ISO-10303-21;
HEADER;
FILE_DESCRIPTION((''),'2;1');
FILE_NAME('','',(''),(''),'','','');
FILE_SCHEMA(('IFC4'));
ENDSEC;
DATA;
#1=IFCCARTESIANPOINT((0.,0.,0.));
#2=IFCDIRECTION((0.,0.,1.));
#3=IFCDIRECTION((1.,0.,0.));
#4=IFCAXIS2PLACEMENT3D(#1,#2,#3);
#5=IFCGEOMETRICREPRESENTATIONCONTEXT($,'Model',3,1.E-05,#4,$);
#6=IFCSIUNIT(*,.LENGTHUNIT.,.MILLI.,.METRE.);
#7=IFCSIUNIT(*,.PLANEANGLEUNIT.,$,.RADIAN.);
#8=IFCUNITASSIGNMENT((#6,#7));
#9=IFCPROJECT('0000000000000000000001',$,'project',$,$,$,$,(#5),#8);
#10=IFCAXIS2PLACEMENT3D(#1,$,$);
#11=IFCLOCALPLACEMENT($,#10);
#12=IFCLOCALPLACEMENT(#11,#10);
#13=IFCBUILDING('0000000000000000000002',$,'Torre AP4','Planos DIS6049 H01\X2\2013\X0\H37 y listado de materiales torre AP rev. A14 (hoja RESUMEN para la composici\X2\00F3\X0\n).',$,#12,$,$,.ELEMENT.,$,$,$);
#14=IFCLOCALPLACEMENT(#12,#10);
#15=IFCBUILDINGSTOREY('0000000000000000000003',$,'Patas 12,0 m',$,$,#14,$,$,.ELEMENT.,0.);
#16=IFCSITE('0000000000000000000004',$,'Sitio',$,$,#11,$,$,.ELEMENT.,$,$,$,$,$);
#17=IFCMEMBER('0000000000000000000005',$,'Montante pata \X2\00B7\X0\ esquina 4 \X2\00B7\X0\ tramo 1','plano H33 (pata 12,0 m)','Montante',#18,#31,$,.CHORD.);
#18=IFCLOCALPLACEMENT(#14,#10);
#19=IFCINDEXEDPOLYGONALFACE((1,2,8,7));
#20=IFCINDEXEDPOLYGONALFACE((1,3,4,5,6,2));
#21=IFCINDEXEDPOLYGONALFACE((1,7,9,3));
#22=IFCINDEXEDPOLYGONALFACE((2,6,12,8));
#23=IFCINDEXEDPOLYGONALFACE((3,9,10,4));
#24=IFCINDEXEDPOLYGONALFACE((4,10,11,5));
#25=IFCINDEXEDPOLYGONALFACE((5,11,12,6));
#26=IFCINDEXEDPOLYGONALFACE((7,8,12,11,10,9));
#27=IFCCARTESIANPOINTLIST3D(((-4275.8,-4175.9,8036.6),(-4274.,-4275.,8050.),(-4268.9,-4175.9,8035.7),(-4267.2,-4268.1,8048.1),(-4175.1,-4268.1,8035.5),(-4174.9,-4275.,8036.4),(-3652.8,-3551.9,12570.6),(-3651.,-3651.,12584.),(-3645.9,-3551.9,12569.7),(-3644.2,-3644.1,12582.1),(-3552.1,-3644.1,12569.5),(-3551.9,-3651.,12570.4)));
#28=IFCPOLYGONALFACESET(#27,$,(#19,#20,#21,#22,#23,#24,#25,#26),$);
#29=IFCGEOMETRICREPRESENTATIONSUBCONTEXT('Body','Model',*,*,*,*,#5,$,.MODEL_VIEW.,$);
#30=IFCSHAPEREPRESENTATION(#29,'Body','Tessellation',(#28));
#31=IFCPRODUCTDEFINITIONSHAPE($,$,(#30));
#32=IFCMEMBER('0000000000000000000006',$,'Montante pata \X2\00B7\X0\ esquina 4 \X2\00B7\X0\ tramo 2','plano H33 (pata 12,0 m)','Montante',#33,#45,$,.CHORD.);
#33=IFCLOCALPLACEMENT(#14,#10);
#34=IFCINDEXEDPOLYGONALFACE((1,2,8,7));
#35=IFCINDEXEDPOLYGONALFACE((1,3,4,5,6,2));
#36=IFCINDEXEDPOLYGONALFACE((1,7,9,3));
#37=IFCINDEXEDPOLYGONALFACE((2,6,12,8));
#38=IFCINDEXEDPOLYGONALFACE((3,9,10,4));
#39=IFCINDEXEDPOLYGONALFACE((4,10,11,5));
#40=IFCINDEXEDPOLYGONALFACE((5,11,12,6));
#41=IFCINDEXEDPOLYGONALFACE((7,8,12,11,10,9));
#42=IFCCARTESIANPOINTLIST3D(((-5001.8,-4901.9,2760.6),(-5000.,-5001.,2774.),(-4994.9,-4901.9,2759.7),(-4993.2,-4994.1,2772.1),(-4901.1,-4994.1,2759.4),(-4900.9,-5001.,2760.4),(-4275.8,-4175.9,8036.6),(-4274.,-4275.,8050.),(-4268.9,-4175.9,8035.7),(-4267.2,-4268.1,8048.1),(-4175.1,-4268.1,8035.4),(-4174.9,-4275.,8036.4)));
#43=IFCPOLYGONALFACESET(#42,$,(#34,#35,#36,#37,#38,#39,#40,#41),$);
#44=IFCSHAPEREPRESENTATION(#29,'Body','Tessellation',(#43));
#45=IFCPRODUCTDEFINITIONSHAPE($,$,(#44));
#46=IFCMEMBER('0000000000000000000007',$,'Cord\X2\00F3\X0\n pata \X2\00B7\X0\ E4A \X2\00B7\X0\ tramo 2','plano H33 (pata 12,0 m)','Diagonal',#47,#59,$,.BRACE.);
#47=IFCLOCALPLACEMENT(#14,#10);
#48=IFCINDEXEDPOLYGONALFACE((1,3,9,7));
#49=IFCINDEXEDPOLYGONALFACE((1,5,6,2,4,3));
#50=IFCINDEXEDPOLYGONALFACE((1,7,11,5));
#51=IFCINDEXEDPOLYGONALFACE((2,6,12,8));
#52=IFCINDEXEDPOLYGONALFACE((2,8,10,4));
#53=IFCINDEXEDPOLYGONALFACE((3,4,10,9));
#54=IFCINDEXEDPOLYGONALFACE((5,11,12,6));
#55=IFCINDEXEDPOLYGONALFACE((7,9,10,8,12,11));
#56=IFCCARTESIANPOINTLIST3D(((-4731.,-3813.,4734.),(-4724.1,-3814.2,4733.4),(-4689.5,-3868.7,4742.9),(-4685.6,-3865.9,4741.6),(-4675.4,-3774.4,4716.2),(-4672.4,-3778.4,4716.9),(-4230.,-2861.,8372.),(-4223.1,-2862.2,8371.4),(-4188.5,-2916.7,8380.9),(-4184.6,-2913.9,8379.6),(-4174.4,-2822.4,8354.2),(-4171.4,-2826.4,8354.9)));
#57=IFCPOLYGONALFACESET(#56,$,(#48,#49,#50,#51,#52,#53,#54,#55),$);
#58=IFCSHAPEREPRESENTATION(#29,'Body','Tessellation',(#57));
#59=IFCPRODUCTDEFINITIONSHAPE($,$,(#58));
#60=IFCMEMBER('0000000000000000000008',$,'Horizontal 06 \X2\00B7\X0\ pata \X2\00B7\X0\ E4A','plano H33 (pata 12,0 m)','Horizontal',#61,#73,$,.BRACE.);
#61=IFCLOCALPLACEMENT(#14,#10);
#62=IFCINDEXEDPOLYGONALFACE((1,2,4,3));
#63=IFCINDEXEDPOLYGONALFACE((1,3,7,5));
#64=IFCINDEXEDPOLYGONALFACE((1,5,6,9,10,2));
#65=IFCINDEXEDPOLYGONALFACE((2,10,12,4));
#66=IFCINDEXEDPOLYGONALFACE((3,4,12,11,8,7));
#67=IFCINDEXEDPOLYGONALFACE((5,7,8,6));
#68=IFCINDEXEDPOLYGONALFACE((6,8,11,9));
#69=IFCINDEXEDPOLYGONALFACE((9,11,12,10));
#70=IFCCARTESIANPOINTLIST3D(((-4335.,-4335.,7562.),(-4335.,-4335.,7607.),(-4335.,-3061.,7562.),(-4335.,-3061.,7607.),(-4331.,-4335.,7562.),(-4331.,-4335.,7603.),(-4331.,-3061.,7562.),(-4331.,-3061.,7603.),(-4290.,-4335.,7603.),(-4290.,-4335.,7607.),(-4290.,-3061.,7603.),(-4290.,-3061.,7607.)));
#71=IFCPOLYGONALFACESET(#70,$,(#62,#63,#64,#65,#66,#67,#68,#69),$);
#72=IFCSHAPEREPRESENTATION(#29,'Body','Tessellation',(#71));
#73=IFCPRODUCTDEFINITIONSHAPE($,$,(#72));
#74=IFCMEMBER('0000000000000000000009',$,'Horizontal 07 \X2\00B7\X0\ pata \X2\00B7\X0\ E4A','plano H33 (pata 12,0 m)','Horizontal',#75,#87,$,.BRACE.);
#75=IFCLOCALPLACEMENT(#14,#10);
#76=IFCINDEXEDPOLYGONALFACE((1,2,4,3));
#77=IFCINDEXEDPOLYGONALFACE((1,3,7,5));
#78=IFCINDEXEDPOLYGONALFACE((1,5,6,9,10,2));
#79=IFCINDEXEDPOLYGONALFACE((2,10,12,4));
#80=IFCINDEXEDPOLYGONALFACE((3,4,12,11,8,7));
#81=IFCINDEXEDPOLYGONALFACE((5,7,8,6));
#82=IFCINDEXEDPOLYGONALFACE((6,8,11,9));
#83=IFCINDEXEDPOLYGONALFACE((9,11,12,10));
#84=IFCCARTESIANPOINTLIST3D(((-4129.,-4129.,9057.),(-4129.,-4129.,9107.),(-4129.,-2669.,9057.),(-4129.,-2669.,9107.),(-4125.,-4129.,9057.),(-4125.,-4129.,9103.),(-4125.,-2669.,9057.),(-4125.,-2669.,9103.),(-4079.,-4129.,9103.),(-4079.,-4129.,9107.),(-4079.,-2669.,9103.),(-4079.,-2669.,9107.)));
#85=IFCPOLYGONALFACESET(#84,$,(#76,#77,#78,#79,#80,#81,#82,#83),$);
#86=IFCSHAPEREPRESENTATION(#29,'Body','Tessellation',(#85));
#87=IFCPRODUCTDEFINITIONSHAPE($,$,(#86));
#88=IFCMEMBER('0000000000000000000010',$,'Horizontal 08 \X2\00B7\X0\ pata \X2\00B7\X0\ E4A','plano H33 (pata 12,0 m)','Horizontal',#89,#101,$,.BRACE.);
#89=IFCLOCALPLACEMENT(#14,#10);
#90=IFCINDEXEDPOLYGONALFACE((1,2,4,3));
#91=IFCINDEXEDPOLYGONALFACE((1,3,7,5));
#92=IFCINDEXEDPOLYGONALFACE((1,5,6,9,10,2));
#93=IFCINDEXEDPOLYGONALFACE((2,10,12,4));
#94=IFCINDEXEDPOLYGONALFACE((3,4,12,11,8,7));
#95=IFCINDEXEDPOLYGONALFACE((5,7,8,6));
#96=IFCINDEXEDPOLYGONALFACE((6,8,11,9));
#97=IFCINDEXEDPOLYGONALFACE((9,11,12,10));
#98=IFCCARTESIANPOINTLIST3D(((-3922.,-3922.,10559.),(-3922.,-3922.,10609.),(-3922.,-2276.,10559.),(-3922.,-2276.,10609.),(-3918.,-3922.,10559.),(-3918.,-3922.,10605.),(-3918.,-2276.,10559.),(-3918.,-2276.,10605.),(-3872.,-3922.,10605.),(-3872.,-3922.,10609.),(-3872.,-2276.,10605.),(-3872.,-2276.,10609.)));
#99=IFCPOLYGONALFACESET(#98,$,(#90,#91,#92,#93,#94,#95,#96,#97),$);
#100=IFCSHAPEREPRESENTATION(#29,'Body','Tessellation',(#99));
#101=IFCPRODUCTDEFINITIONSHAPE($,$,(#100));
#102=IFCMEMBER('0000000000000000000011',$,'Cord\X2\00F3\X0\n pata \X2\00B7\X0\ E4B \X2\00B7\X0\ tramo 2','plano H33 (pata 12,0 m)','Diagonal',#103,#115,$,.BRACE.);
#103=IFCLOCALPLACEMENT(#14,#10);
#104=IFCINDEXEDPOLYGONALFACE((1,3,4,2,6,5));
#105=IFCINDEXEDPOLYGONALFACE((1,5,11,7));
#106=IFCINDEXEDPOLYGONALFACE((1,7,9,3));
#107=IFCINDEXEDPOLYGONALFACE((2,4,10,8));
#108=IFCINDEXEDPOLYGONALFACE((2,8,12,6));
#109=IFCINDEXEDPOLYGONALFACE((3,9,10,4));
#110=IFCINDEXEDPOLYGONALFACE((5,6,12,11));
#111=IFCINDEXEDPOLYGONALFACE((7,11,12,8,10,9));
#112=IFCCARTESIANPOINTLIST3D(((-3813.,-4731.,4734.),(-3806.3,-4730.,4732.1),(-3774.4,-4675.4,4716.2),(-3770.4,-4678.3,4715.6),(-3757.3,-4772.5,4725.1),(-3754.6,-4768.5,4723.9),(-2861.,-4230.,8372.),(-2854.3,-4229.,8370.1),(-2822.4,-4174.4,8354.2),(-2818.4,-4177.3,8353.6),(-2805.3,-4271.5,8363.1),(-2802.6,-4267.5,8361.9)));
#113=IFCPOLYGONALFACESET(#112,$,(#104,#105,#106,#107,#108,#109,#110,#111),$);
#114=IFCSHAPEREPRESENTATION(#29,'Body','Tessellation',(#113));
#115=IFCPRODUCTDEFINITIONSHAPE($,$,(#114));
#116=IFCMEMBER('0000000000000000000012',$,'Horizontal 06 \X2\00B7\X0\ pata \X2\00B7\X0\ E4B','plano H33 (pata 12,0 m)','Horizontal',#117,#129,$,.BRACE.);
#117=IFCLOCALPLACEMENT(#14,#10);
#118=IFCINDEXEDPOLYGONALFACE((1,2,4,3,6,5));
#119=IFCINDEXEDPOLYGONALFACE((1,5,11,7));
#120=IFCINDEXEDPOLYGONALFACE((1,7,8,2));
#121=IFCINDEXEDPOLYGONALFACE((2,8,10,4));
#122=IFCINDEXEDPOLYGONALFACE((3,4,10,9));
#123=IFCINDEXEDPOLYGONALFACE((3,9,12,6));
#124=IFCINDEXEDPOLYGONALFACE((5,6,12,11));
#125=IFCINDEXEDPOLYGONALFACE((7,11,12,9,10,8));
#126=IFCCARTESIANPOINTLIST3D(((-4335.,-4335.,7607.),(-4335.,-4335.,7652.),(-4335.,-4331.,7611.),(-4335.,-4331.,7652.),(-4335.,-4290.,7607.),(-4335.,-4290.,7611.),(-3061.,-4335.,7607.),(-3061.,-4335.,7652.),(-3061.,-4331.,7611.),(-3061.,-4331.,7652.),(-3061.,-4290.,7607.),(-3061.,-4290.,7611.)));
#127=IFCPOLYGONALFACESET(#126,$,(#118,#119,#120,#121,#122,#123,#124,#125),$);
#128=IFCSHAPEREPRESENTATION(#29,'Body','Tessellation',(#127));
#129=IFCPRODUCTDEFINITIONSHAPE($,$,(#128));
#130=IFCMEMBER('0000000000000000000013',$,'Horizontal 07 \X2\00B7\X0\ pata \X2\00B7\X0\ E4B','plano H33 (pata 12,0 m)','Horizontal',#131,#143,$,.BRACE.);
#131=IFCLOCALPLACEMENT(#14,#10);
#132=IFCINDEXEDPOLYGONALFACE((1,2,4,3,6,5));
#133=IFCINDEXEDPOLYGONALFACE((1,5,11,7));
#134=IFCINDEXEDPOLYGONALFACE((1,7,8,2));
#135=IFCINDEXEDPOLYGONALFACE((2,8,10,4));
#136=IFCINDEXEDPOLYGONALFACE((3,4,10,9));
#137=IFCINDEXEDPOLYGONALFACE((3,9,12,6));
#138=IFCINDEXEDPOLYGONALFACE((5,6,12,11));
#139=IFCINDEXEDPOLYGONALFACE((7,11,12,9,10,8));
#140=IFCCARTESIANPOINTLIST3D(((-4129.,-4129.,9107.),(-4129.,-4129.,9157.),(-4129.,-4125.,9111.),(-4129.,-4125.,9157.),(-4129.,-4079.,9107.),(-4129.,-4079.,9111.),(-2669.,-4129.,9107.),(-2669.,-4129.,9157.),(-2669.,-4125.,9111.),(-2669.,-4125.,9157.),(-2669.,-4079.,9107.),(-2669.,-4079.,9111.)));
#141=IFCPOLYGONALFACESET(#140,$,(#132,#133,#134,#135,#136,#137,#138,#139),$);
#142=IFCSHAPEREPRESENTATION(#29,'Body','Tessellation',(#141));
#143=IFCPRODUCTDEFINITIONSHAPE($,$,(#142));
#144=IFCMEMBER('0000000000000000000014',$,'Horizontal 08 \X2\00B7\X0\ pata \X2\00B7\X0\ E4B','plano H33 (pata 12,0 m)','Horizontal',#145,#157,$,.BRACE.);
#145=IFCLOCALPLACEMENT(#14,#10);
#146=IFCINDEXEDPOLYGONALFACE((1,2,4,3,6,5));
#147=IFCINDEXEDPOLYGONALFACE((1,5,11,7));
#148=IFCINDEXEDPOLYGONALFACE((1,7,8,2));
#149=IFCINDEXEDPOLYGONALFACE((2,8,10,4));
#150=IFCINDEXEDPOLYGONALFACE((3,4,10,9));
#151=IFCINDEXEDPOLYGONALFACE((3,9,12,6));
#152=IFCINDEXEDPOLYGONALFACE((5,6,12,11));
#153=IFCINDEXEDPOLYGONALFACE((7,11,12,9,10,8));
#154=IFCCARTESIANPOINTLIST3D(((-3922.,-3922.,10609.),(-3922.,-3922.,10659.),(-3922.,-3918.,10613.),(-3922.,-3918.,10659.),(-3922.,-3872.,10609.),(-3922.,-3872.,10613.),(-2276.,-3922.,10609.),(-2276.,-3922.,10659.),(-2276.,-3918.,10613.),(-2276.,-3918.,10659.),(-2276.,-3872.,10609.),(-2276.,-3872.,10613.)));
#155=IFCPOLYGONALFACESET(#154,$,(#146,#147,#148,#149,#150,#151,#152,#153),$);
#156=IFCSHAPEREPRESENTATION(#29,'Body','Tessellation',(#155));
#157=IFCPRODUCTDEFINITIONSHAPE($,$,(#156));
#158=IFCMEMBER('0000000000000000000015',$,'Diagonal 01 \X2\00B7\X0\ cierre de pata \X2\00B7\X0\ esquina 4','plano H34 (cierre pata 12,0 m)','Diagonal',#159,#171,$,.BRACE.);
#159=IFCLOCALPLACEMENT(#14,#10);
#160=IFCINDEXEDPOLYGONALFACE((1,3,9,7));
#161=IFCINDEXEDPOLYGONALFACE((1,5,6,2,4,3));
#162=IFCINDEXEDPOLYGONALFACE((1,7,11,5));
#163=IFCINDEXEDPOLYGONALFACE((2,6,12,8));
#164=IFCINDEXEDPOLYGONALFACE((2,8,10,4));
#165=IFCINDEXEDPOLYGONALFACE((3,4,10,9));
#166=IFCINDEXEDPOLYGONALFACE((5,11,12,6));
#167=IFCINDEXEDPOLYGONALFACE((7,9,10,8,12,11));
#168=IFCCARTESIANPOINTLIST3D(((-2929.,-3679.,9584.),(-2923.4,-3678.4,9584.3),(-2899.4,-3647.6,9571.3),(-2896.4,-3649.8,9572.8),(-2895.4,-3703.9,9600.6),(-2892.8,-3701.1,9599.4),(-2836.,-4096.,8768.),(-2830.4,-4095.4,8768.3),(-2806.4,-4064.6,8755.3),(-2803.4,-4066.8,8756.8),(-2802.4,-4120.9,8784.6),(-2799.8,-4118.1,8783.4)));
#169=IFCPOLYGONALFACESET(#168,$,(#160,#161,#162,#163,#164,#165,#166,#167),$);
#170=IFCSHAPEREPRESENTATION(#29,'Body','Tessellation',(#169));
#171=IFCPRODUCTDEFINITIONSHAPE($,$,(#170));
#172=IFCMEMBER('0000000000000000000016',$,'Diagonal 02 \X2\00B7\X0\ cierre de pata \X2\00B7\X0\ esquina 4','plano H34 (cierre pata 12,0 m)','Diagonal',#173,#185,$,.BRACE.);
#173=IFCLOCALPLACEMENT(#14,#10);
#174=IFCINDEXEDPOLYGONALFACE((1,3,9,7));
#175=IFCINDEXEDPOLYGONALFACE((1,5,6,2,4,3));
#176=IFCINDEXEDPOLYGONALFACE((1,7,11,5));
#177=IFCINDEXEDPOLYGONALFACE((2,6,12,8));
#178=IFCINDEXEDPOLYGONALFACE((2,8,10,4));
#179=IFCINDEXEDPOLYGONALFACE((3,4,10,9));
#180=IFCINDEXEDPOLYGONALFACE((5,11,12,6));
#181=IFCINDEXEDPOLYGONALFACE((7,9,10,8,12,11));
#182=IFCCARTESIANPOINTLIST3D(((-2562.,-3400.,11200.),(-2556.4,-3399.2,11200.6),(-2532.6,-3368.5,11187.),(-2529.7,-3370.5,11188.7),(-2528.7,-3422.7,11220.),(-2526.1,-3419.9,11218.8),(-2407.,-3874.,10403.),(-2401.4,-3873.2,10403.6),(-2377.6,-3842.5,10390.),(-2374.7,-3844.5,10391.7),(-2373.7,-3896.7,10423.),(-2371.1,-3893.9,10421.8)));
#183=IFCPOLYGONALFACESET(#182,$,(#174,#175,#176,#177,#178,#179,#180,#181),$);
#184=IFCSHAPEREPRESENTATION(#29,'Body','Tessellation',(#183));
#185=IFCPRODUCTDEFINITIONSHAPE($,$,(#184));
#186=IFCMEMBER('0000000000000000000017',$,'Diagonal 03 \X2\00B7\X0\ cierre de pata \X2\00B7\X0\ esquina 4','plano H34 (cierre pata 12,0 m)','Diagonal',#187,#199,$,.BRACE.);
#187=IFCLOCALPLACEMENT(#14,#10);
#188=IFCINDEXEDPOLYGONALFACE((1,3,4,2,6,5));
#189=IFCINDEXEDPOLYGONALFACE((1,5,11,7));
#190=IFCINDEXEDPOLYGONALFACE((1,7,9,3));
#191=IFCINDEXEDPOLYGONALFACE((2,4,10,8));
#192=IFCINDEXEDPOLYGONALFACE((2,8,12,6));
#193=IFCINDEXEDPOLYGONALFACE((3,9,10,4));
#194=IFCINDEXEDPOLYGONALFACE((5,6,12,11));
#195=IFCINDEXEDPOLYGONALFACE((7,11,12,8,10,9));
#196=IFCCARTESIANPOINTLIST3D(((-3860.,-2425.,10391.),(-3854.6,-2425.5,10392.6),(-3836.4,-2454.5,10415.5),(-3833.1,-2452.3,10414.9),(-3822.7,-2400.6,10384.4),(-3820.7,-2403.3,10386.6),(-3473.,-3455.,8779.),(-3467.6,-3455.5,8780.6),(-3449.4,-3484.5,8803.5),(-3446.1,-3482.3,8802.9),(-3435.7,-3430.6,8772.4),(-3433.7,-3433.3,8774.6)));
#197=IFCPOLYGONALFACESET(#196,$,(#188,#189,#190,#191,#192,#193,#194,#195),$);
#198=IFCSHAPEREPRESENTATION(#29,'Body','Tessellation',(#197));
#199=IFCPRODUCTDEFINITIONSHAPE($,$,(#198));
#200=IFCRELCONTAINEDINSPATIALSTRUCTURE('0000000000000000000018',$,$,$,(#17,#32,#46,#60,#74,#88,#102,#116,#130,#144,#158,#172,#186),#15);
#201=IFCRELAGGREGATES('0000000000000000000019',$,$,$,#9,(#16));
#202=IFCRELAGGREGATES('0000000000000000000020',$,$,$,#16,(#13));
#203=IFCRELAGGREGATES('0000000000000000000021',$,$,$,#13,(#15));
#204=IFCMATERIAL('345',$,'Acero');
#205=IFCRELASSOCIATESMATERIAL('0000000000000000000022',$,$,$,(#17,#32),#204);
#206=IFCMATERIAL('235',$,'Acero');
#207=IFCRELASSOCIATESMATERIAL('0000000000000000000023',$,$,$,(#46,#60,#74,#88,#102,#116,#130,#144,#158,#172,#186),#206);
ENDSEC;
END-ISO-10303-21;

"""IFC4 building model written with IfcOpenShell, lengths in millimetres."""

from ifc_helpers import new_model, si_unit, frame, frame_2d, origin, origin_with_axes, place, context, subcontext, project, spatial, l_section, extrude, material, element, save


model = new_model("IFC4")

# Units and contexts
model_context = context("Model", 3, precision=1e-05, world=origin_with_axes())
body_context = subcontext(model_context, "Body", "Model", "MODEL_VIEW")
ifc_project = project(units=[si_unit("LENGTHUNIT", "METRE", prefix="MILLI"), si_unit("PLANEANGLEUNIT", "RADIAN")], contexts=[model_context])

# Site, building, storey
site_placement = place(None, origin())
site = spatial("IfcSite", under=ifc_project, at=site_placement, Name="Sitio", CompositionType="ELEMENT")
building_placement = place(site_placement, origin())
building = spatial("IfcBuilding", under=site, at=building_placement, Name="Torre AP4", Description="Planos DIS6049 H01–H37 y listado de materiales torre AP rev. A14 (hoja RESUMEN para la composición).", CompositionType="ELEMENT")
storey_placement = place(building_placement, origin())
storey = spatial("IfcBuildingStorey", under=building, at=storey_placement, Name="Patas 12,0 m", CompositionType="ELEMENT", Elevation=0.0)

# Members
ifc_material_1 = material(Name="345", Category="Acero")
member_1_placement = place(storey_placement, frame((-3651.0, -3651.0, 12584.0), z_axis=(-0.134879, -0.135096, -0.981609), x_axis=(-0.01839, 0.990833, -0.133838)))
element("IfcMember", 1, at=member_1_placement, inside=storey, material=ifc_material_1, Name="Montante pata · esquina 4 · tramo 1", Description="plano H33 (pata 12,0 m)", ObjectType="Montante", PredefinedType="CHORD", context=body_context, shape_type="SweptSolid", body=[
    extrude(l_section(Depth=100.0, Width=100.0, Thickness=7.0, at=frame_2d((50.0, 50.0))), None, (0.0, 0.0, 1.0), 4618.9),
])
member_2_placement = place(storey_placement, frame((-4274.0, -4275.0, 8050.0), z_axis=(-0.13507, -0.13507, -0.981586), x_axis=(-0.018413, 0.990836, -0.13381)))
element("IfcMember", 2, at=member_2_placement, inside=storey, material=ifc_material_1, Name="Montante pata · esquina 4 · tramo 2", Description="plano H33 (pata 12,0 m)", ObjectType="Montante", PredefinedType="CHORD", context=body_context, shape_type="SweptSolid", body=[
    extrude(l_section(Depth=100.0, Width=100.0, Thickness=7.0, at=frame_2d((50.0, 50.0))), None, (0.0, 0.0, 1.0), 5375.0),
])
ifc_material_2 = material(Name="235", Category="Acero")
member_3_placement = place(storey_placement, frame((-4230.0, -2861.0, 8372.0), z_axis=(-0.13206, -0.250941, -0.958952), x_axis=(0.794662, 0.551475, -0.253747)))
element("IfcMember", 3, at=member_3_placement, inside=storey, material=ifc_material_2, Name="Cordón pata · E4A · tramo 2", Description="plano H33 (pata 12,0 m)", ObjectType="Diagonal", PredefinedType="BRACE", context=body_context, shape_type="SweptSolid", body=[
    extrude(l_section(Depth=70.0, Width=70.0, Thickness=5.0, at=frame_2d((35.0, 35.0))), None, (0.0, 0.0, 1.0), 3793.7),
])
member_4_placement = place(storey_placement, frame((-4335.0, -4335.0, 7607.0), z_axis=(0.0, 1.0, 0.0), x_axis=(1.0, 0.0, 0.0)))
element("IfcMember", 4, at=member_4_placement, inside=storey, material=ifc_material_2, Name="Horizontal 06 · pata · E4A", Description="plano H33 (pata 12,0 m)", ObjectType="Horizontal", PredefinedType="BRACE", context=body_context, shape_type="SweptSolid", body=[
    extrude(l_section(Depth=45.0, Width=45.0, Thickness=4.0, at=frame_2d((22.5, 22.5))), None, (0.0, 0.0, 1.0), 1274.0),
])
member_5_placement = place(storey_placement, frame((-4129.0, -4129.0, 9107.0), z_axis=(0.0, 1.0, 0.0), x_axis=(1.0, 0.0, 0.0)))
element("IfcMember", 5, at=member_5_placement, inside=storey, material=ifc_material_2, Name="Horizontal 07 · pata · E4A", Description="plano H33 (pata 12,0 m)", ObjectType="Horizontal", PredefinedType="BRACE", context=body_context, shape_type="SweptSolid", body=[
    extrude(l_section(Depth=50.0, Width=50.0, Thickness=4.0, at=frame_2d((25.0, 25.0))), None, (0.0, 0.0, 1.0), 1460.0),
])
member_6_placement = place(storey_placement, frame((-3922.0, -3922.0, 10609.0), z_axis=(0.0, 1.0, 0.0), x_axis=(1.0, 0.0, 0.0)))
element("IfcMember", 6, at=member_6_placement, inside=storey, material=ifc_material_2, Name="Horizontal 08 · pata · E4A", Description="plano H33 (pata 12,0 m)", ObjectType="Horizontal", PredefinedType="BRACE", context=body_context, shape_type="SweptSolid", body=[
    extrude(l_section(Depth=50.0, Width=50.0, Thickness=4.0, at=frame_2d((25.0, 25.0))), None, (0.0, 0.0, 1.0), 1646.0),
])
member_7_placement = place(storey_placement, frame((-2861.0, -4230.0, 8372.0), z_axis=(-0.250941, -0.13206, -0.958952), x_axis=(0.551475, 0.794662, -0.253747)))
element("IfcMember", 7, at=member_7_placement, inside=storey, material=ifc_material_2, Name="Cordón pata · E4B · tramo 2", Description="plano H33 (pata 12,0 m)", ObjectType="Diagonal", PredefinedType="BRACE", context=body_context, shape_type="SweptSolid", body=[
    extrude(l_section(Depth=70.0, Width=70.0, Thickness=5.0, at=frame_2d((35.0, 35.0))), None, (0.0, 0.0, 1.0), 3793.7),
])
member_8_placement = place(storey_placement, frame((-4335.0, -4335.0, 7607.0), z_axis=(1.0, 0.0, 0.0), x_axis=(0.0, 1.0, 0.0)))
element("IfcMember", 8, at=member_8_placement, inside=storey, material=ifc_material_2, Name="Horizontal 06 · pata · E4B", Description="plano H33 (pata 12,0 m)", ObjectType="Horizontal", PredefinedType="BRACE", context=body_context, shape_type="SweptSolid", body=[
    extrude(l_section(Depth=45.0, Width=45.0, Thickness=4.0, at=frame_2d((22.5, 22.5))), None, (0.0, 0.0, 1.0), 1274.0),
])
member_9_placement = place(storey_placement, frame((-4129.0, -4129.0, 9107.0), z_axis=(1.0, 0.0, 0.0), x_axis=(0.0, 1.0, 0.0)))
element("IfcMember", 9, at=member_9_placement, inside=storey, material=ifc_material_2, Name="Horizontal 07 · pata · E4B", Description="plano H33 (pata 12,0 m)", ObjectType="Horizontal", PredefinedType="BRACE", context=body_context, shape_type="SweptSolid", body=[
    extrude(l_section(Depth=50.0, Width=50.0, Thickness=4.0, at=frame_2d((25.0, 25.0))), None, (0.0, 0.0, 1.0), 1460.0),
])
member_10_placement = place(storey_placement, frame((-3922.0, -3922.0, 10609.0), z_axis=(1.0, 0.0, 0.0), x_axis=(0.0, 1.0, 0.0)))
element("IfcMember", 10, at=member_10_placement, inside=storey, material=ifc_material_2, Name="Horizontal 08 · pata · E4B", Description="plano H33 (pata 12,0 m)", ObjectType="Horizontal", PredefinedType="BRACE", context=body_context, shape_type="SweptSolid", body=[
    extrude(l_section(Depth=50.0, Width=50.0, Thickness=4.0, at=frame_2d((25.0, 25.0))), None, (0.0, 0.0, 1.0), 1646.0),
])
member_11_placement = place(storey_placement, frame((-2929.0, -3679.0, 9584.0), z_axis=(0.100968, -0.452728, -0.885914), x_axis=(0.657265, 0.698827, -0.282212)))
element("IfcMember", 11, at=member_11_placement, inside=storey, material=ifc_material_2, Name="Diagonal 01 · cierre de pata · esquina 4", Description="plano H34 (cierre pata 12,0 m)", ObjectType="Diagonal", PredefinedType="BRACE", context=body_context, shape_type="SweptSolid", body=[
    extrude(l_section(Depth=45.0, Width=45.0, Thickness=4.0, at=frame_2d((22.5, 22.5))), None, (0.0, 0.0, 1.0), 921.1),
])
member_12_placement = place(storey_placement, frame((-2562.0, -3400.0, 11200.0), z_axis=(0.164865, -0.504167, -0.847724), x_axis=(0.65241, 0.700338, -0.289632)))
element("IfcMember", 12, at=member_12_placement, inside=storey, material=ifc_material_2, Name="Diagonal 02 · cierre de pata · esquina 4", Description="plano H34 (cierre pata 12,0 m)", ObjectType="Diagonal", PredefinedType="BRACE", context=body_context, shape_type="SweptSolid", body=[
    extrude(l_section(Depth=45.0, Width=45.0, Thickness=4.0, at=frame_2d((22.5, 22.5))), None, (0.0, 0.0, 1.0), 940.2),
])
member_13_placement = place(storey_placement, frame((-3860.0, -2425.0, 10391.0), z_axis=(0.198287, -0.527739, -0.825938), x_axis=(0.827791, 0.541385, -0.14719)))
element("IfcMember", 13, at=member_13_placement, inside=storey, material=ifc_material_2, Name="Diagonal 03 · cierre de pata · esquina 4", Description="plano H34 (cierre pata 12,0 m)", ObjectType="Diagonal", PredefinedType="BRACE", context=body_context, shape_type="SweptSolid", body=[
    extrude(l_section(Depth=45.0, Width=45.0, Thickness=4.0, at=frame_2d((22.5, 22.5))), None, (0.0, 0.0, 1.0), 1951.7),
])

save(model, "model.ifc")
